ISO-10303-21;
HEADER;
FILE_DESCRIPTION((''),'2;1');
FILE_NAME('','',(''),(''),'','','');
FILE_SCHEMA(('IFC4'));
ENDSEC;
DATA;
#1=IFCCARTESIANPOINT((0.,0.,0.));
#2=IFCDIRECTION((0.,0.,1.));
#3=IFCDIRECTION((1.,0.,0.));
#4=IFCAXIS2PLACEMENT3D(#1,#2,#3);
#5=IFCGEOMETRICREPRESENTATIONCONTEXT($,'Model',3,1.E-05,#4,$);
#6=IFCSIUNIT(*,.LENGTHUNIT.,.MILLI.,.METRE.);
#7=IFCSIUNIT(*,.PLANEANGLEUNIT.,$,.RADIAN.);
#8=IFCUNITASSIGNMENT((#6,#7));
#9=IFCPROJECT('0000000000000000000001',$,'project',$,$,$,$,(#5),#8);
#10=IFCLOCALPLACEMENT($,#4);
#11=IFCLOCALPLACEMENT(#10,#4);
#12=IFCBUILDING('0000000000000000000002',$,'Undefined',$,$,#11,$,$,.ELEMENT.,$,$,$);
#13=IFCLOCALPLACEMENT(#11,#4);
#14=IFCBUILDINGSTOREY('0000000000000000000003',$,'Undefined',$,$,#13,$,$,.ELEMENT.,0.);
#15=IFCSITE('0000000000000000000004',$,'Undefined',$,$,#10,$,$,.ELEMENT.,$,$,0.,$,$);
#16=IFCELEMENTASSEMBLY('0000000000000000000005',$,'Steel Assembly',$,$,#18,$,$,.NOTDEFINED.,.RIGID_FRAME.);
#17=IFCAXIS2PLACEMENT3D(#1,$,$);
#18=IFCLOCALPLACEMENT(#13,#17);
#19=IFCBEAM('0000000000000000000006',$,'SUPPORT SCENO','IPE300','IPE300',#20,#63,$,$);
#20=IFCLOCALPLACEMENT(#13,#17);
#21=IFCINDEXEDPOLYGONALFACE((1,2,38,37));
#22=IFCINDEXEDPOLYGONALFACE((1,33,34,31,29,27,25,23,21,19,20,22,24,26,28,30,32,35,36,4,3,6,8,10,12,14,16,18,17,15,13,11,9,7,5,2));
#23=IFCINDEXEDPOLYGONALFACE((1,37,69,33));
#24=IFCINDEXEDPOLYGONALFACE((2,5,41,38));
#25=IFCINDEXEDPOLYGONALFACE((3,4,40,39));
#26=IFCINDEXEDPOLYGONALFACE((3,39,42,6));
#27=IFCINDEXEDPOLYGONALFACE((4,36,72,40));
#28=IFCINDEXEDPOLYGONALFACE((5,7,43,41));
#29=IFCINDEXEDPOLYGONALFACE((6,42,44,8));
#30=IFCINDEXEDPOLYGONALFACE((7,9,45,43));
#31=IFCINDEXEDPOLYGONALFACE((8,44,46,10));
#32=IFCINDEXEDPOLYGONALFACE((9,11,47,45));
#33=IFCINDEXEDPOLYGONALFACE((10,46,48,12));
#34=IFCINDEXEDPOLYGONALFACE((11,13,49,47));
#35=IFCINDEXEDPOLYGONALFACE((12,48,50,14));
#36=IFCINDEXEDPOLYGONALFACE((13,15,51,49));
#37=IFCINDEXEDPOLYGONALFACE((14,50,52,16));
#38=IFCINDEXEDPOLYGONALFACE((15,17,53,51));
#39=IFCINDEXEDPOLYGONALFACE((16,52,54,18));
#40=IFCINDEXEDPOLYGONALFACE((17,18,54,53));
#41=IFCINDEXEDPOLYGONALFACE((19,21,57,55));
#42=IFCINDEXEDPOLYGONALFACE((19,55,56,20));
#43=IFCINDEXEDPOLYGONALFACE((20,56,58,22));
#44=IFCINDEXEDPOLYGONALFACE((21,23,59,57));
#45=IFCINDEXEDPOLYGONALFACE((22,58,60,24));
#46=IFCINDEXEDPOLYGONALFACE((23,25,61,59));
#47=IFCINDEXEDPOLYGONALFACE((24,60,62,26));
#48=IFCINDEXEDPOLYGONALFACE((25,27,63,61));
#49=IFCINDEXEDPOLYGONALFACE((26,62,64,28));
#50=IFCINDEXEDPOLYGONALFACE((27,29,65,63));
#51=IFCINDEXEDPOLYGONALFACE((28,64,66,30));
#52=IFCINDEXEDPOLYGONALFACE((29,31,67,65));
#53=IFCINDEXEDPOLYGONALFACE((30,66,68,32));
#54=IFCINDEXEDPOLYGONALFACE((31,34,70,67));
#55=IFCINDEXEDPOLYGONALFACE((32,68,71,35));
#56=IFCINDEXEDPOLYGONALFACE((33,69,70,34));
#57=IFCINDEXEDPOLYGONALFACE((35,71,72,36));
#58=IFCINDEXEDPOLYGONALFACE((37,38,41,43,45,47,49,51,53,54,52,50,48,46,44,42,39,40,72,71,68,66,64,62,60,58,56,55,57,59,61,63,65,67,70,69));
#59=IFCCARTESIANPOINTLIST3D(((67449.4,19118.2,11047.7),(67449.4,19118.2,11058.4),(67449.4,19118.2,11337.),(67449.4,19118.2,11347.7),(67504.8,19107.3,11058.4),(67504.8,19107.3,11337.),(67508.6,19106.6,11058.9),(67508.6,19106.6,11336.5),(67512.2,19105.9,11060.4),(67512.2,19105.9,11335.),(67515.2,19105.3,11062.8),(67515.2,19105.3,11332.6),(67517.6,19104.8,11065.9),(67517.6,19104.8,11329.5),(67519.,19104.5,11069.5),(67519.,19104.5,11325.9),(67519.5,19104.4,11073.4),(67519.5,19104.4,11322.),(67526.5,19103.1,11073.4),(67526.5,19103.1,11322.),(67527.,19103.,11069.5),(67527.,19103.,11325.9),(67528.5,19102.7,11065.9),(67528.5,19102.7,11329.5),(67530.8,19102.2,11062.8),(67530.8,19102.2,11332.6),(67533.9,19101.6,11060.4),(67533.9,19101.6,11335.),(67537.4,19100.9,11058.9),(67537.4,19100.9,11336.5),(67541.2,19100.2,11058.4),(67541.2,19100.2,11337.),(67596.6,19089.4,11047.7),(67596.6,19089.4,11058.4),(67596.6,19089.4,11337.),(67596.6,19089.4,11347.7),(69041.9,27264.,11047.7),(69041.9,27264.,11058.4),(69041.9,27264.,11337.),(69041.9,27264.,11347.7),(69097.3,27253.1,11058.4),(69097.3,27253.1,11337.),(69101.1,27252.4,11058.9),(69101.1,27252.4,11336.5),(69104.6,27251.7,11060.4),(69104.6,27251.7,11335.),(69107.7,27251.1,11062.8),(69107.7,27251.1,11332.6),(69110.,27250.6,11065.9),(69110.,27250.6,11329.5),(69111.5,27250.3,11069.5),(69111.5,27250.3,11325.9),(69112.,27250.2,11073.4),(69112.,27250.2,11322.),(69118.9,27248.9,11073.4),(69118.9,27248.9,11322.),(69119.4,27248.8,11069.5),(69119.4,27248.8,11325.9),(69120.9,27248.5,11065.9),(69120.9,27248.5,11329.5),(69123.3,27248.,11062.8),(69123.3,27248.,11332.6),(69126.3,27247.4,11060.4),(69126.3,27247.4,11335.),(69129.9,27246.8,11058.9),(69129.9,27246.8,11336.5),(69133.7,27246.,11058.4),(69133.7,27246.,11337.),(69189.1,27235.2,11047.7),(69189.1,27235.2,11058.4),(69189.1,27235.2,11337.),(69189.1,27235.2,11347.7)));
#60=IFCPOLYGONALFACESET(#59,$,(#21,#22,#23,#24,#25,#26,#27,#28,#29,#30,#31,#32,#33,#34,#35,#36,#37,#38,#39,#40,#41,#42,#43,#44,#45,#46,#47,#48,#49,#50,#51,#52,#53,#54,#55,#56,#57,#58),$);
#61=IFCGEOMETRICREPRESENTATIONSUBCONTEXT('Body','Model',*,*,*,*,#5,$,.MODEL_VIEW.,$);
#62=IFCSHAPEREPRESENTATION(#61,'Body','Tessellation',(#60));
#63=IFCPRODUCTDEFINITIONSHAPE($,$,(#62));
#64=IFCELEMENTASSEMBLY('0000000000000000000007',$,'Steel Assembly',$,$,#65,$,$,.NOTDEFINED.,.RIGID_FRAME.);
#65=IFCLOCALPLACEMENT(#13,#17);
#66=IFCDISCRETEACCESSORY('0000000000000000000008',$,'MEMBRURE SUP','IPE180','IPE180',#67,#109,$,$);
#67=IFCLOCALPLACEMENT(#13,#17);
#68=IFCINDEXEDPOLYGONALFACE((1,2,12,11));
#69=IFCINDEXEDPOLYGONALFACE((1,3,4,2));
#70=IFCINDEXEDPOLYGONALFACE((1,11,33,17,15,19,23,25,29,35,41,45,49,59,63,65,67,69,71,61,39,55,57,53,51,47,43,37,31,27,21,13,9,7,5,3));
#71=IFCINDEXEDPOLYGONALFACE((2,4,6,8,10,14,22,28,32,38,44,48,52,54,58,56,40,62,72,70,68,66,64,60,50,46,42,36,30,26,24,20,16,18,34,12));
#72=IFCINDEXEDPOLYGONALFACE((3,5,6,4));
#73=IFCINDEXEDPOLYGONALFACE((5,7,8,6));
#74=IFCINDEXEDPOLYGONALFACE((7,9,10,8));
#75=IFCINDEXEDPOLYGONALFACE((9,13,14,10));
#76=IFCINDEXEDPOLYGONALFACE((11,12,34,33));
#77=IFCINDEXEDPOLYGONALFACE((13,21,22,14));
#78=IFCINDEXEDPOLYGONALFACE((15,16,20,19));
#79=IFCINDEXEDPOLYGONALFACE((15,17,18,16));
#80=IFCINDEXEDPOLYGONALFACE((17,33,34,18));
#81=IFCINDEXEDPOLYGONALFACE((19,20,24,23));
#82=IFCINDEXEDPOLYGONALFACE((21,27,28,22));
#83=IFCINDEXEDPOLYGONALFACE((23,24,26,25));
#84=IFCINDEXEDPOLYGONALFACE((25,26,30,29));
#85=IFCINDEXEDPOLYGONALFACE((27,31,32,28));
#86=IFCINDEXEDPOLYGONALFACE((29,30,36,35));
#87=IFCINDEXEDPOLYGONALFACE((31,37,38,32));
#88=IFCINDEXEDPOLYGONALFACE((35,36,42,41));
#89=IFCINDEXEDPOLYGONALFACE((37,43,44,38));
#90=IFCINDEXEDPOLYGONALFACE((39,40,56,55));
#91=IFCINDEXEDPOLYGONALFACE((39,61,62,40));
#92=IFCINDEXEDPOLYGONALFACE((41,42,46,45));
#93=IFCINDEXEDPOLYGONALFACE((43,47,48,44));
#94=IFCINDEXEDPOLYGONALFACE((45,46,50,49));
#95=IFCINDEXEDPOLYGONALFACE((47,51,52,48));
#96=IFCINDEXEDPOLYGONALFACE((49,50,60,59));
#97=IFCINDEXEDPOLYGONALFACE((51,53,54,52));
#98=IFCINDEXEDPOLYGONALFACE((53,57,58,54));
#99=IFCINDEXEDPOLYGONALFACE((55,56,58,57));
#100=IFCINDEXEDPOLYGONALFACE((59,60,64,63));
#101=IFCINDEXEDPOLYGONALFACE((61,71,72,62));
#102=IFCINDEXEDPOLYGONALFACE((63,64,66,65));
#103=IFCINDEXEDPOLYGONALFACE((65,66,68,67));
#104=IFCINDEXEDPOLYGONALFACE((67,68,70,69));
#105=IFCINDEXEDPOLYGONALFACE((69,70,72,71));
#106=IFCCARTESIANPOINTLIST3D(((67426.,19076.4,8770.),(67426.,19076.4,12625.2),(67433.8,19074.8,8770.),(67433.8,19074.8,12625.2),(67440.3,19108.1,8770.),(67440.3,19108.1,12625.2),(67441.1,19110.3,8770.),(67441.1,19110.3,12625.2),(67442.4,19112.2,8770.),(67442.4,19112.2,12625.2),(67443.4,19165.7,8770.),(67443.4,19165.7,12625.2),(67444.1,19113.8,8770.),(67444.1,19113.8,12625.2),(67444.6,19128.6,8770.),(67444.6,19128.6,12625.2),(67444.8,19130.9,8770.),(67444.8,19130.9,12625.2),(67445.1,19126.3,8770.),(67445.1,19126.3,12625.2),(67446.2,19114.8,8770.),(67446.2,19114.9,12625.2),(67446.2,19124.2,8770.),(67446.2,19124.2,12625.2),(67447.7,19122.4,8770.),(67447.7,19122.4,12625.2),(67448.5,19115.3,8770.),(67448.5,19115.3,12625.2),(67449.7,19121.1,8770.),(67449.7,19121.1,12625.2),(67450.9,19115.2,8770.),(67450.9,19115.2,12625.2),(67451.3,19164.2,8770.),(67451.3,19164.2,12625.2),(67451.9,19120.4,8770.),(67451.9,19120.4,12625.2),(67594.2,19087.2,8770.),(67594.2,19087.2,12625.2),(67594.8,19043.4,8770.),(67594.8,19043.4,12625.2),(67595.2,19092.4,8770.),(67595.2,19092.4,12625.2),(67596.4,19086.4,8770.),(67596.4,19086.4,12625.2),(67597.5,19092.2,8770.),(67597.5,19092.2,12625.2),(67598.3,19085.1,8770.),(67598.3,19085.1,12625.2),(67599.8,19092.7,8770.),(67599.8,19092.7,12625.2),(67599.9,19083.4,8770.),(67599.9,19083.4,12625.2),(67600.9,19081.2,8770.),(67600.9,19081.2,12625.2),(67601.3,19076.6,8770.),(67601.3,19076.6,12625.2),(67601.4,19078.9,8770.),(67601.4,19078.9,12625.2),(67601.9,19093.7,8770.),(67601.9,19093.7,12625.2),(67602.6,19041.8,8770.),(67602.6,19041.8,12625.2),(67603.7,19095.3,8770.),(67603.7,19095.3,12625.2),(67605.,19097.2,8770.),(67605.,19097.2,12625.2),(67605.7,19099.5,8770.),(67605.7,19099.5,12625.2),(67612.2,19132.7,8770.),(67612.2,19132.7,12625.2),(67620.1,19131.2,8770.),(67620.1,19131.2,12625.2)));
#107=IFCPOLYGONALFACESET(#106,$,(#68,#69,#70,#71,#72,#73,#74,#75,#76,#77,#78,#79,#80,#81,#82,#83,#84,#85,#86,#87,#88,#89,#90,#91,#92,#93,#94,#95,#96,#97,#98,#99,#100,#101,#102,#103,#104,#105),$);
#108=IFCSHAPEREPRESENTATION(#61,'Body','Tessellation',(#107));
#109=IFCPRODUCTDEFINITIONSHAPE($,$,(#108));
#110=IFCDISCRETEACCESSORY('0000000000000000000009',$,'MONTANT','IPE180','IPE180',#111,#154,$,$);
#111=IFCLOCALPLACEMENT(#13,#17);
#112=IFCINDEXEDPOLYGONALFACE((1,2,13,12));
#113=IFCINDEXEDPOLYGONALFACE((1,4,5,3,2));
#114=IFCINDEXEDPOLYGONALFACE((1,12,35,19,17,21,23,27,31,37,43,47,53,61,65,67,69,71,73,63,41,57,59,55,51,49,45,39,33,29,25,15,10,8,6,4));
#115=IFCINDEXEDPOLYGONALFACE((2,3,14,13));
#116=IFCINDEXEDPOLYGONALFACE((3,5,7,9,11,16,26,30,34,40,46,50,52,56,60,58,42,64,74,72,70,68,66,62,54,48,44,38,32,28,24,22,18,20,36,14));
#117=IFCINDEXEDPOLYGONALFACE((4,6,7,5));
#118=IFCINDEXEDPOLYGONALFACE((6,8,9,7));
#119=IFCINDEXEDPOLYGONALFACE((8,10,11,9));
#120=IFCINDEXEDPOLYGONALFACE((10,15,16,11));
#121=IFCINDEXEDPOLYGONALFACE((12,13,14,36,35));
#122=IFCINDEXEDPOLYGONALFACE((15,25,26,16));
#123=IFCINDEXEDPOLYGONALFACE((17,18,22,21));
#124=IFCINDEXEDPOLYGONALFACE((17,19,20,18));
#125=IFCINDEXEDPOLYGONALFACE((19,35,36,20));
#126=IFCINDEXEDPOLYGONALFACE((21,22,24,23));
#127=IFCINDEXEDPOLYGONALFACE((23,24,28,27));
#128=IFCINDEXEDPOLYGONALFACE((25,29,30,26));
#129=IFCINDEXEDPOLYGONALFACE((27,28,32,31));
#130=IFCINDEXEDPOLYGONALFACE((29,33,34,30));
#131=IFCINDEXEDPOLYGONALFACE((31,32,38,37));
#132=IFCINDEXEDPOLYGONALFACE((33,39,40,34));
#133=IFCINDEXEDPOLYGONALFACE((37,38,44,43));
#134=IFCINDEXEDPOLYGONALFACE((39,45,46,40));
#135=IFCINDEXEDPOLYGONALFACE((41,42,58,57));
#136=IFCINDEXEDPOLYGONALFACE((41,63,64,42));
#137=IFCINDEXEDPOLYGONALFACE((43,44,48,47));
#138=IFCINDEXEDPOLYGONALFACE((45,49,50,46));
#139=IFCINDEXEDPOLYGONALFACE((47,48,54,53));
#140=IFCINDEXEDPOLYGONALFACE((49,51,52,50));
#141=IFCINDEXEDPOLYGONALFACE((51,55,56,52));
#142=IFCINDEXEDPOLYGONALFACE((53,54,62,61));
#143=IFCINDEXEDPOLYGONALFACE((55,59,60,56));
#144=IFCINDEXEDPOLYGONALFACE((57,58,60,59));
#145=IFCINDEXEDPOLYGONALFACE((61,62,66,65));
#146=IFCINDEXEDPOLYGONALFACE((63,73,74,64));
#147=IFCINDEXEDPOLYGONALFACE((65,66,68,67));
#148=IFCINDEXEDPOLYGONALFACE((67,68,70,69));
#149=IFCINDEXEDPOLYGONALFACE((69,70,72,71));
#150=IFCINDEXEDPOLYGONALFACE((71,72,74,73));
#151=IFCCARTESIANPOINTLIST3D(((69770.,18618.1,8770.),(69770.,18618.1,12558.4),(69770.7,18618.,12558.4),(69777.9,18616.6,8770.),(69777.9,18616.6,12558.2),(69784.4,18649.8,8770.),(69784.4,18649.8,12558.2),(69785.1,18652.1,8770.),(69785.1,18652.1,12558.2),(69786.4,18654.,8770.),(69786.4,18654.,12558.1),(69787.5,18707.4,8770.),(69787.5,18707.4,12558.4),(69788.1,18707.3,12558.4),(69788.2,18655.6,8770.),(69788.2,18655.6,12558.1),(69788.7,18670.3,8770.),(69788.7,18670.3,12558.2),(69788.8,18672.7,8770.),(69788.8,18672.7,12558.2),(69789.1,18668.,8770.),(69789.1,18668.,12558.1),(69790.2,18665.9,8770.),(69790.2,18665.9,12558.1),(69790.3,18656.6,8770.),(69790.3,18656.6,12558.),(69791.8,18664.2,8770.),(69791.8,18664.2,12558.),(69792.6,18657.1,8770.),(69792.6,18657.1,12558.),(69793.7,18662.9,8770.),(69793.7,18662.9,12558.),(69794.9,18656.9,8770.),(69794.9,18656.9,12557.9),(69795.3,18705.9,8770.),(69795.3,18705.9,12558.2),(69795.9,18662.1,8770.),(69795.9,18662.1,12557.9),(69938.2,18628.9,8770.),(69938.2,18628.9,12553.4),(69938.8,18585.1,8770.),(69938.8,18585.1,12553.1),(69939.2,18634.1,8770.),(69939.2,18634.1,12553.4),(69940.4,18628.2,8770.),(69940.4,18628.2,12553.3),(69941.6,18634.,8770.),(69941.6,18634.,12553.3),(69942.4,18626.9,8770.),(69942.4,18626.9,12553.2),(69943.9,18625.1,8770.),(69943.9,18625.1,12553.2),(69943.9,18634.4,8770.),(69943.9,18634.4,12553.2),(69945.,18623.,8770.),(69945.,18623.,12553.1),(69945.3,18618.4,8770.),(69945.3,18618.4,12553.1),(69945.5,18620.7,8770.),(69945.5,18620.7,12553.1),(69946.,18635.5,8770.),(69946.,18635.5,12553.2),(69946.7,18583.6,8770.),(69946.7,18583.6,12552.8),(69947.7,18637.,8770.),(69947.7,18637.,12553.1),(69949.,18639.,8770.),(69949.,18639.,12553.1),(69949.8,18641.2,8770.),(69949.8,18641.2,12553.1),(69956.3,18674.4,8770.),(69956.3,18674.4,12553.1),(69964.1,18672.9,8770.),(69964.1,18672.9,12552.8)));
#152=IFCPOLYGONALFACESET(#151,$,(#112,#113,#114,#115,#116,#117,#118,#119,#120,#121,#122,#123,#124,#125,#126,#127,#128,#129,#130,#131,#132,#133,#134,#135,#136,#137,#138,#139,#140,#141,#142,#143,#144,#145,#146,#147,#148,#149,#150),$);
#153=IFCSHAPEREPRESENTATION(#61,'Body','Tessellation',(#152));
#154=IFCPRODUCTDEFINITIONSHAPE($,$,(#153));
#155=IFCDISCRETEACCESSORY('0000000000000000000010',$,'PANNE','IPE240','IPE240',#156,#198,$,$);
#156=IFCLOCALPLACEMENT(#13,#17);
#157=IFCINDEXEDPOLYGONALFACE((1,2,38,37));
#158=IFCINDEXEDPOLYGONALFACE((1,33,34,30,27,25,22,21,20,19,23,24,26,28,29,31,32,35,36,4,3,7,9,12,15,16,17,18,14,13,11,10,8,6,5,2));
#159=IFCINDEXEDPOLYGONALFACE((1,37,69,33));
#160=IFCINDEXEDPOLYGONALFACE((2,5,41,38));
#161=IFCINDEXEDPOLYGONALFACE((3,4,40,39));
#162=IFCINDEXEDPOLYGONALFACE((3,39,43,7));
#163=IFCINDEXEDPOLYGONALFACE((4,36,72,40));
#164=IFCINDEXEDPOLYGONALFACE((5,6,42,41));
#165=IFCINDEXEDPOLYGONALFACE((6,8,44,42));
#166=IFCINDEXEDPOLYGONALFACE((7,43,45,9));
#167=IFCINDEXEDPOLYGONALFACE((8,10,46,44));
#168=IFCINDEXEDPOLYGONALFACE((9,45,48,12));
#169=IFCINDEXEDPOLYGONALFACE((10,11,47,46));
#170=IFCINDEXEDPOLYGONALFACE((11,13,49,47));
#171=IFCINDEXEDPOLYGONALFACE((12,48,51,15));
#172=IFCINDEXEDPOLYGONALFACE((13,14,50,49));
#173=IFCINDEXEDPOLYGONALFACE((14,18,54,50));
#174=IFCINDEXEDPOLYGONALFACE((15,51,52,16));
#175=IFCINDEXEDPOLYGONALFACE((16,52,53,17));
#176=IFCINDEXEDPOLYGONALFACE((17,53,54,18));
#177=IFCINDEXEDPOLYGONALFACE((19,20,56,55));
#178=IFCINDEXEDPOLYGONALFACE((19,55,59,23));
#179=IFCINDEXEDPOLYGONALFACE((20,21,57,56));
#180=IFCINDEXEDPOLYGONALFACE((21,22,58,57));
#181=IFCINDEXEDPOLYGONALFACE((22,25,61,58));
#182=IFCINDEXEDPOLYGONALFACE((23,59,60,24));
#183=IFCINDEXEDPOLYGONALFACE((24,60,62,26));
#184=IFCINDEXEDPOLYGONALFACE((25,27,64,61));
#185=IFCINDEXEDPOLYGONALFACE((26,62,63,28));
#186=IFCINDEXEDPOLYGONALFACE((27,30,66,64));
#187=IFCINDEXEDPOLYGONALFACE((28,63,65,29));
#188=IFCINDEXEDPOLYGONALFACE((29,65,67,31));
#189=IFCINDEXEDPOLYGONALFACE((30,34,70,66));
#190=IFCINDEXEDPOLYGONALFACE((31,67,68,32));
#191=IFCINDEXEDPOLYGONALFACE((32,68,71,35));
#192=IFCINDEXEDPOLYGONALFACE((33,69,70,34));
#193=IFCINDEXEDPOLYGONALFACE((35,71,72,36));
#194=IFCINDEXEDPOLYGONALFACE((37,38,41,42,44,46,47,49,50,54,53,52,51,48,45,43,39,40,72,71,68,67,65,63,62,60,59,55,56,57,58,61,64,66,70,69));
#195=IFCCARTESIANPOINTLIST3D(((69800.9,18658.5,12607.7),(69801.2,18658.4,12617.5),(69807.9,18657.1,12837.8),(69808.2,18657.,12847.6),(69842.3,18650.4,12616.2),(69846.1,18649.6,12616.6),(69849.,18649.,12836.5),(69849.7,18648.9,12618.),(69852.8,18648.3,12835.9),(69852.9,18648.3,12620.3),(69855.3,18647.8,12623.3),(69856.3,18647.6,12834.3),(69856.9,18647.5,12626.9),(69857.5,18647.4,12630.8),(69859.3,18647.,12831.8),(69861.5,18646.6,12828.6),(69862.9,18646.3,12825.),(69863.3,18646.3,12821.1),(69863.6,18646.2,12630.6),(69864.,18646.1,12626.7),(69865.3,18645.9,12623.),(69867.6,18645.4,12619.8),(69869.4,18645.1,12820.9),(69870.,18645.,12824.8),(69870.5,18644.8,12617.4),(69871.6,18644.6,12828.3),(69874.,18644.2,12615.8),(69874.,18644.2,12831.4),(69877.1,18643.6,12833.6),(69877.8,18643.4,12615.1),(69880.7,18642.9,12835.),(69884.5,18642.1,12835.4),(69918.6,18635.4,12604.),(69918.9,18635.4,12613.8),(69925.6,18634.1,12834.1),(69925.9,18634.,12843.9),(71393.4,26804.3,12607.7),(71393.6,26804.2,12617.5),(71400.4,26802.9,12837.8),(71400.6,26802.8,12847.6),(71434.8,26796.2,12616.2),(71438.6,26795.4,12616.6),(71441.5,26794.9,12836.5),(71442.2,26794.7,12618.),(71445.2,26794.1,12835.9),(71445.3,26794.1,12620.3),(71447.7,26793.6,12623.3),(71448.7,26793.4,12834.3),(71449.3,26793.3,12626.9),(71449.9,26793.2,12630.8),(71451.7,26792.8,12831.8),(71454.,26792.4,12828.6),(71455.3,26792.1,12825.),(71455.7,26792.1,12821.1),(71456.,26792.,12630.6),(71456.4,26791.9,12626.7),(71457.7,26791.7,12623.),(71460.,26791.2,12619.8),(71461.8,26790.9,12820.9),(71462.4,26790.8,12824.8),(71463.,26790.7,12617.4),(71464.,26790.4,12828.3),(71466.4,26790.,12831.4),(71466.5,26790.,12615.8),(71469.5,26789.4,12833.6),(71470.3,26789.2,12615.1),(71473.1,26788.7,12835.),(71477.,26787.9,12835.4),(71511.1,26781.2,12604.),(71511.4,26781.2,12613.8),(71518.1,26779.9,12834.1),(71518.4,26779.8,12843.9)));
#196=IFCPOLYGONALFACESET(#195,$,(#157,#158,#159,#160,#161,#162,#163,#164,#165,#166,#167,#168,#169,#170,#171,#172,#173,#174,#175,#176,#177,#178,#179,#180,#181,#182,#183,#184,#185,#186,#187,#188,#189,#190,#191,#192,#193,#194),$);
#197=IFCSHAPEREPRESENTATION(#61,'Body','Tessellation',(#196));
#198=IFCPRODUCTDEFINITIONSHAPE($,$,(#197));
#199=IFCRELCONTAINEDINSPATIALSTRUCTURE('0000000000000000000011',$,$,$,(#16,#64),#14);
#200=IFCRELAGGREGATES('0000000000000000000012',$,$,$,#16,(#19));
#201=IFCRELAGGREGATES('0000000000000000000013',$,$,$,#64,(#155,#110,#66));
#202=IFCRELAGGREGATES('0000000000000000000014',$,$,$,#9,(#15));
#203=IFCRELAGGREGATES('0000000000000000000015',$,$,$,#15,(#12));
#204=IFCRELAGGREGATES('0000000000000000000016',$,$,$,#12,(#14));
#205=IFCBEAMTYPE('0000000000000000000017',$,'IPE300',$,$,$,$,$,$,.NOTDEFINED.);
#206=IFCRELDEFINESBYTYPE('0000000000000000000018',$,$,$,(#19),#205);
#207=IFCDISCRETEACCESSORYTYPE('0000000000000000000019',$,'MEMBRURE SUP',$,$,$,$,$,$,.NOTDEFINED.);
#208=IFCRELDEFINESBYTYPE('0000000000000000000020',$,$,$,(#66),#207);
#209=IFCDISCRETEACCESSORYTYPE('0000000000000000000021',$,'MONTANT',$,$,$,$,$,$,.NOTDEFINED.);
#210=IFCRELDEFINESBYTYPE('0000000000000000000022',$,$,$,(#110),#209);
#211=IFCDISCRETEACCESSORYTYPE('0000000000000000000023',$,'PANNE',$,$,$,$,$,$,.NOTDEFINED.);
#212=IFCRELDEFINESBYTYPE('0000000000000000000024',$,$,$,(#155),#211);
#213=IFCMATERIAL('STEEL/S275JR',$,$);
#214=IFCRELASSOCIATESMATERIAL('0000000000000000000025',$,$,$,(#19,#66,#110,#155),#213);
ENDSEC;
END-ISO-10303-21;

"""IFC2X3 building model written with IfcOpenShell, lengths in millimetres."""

from ifc_helpers import new_model, si_unit, frame, origin_with_axes, origin_2d_with_axis, place, context, subcontext, project, spatial, i_section, extrude, clip, halfspace, material, type_object, element, aggregate, save


model = new_model("IFC2X3")

# Units and contexts
model_context = context("Model", 3, precision=1e-05, world=origin_with_axes())
body_context = subcontext(model_context, "Body", "Model", "MODEL_VIEW")
ifc_project = project(units=[si_unit("LENGTHUNIT", "METRE", prefix="MILLI"), si_unit("PLANEANGLEUNIT", "RADIAN")], contexts=[model_context])

# Site, building, storey
site_placement = place(None, origin_with_axes())
site = spatial("IfcSite", under=ifc_project, at=site_placement, Name="Undefined", CompositionType="ELEMENT", RefElevation=0.0)
building_placement = place(site_placement, origin_with_axes())
building = spatial("IfcBuilding", under=site, at=building_placement, Name="Undefined", CompositionType="ELEMENT")
storey_placement = place(building_placement, origin_with_axes())
storey = spatial("IfcBuildingStorey", under=building, at=storey_placement, Name="Undefined", CompositionType="ELEMENT", Elevation=0.0)

# Element assembly, beam
ifc_material = material(Name="STEEL/S275JR")
beam_type_1 = type_object("IfcBeamType", Name="IPE300", PredefinedType="NOTDEFINED")
assembly_1_placement = place(storey_placement, origin_with_axes())
assembly_1 = element("IfcElementAssembly", 1, at=assembly_1_placement, inside=storey, Name="Steel Assembly", AssemblyPlace="NOTDEFINED", PredefinedType="RIGID_FRAME")
beam_1_placement = place(assembly_1_placement, frame((67523.0, 19103.8, 11197.7), z_axis=(0.0, 0.0, 1.0), x_axis=(0.191859, 0.981422, 0.0)))
beam_1 = element("IfcBeam", 2, at=beam_1_placement, type_object=beam_type_1, material=ifc_material, Name="SUPPORT SCENO", Description="IPE300", ObjectType="IPE300", context=body_context, shape_type="SweptSolid", body=[
    extrude(i_section(OverallWidth=150.0, OverallDepth=300.0, WebThickness=7.1, FlangeThickness=10.7, FilletRadius=15.0, at=origin_2d_with_axis()), frame((8300.0, 0.0, 0.0), z_axis=(-1.0, 0.0, 0.0), x_axis=(0.0, -1.0, 0.0)), (0.0, 0.0, 1.0), 8300.0),
])
aggregate(assembly_1, [beam_1])

# Element assembly, discrete accessories
assembly_2_placement = place(storey_placement, origin_with_axes())
assembly_2 = element("IfcElementAssembly", 3, at=assembly_2_placement, inside=storey, Name="Steel Assembly", AssemblyPlace="NOTDEFINED", PredefinedType="RIGID_FRAME")
discrete_accessory_type_1 = type_object("IfcDiscreteAccessoryType", Name="MEMBRURE SUP")
discrete_accessory_1_placement = place(assembly_2_placement, frame((67523.0, 19103.8, 12625.2), z_axis=(0.981422, -0.191859, 0.0), x_axis=(-0.000002, 0.0, -1.0)))
discrete_accessory_1 = element("IfcDiscreteAccessory", 4, at=discrete_accessory_1_placement, type_object=discrete_accessory_type_1, material=ifc_material, Name="MEMBRURE SUP", Description="IPE180", ObjectType="IPE180", context=body_context, shape_type="SweptSolid", body=[
    extrude(i_section(OverallWidth=91.0, OverallDepth=180.0, WebThickness=5.3, FlangeThickness=8.0, FilletRadius=9.0, at=origin_2d_with_axis()), frame((3855.2, 0.0, 0.0), z_axis=(-1.0, 0.0, 0.0), x_axis=(0.0, -1.0, 0.0)), (0.0, 0.0, 1.0), 3855.2),
])
discrete_accessory_type_2 = type_object("IfcDiscreteAccessoryType", Name="MONTANT")
discrete_accessory_2_placement = place(assembly_2_placement, frame((69867.1, 18645.5, 12528.2), z_axis=(-0.981422, 0.191859, 0.0), x_axis=(0.0, 0.0, -1.0)))
discrete_accessory_2 = element("IfcDiscreteAccessory", 5, at=discrete_accessory_2_placement, type_object=discrete_accessory_type_2, material=ifc_material, Name="MONTANT", Description="IPE180", ObjectType="IPE180", context=body_context, shape_type="Clipping", body=[
    clip(extrude(i_section(OverallWidth=91.0, OverallDepth=180.0, WebThickness=5.3, FlangeThickness=8.0, FilletRadius=9.0, at=origin_2d_with_axis()), frame((3758.2, 0.0, 0.0), z_axis=(-1.0, 0.0, 0.0), x_axis=(0.0, -1.0, 0.0)), (0.0, 0.0, 1.0), 3788.4), halfspace(frame((-32.4, 1850.0, 158.7), z_axis=(0.99952, 0.0, 0.030984), x_axis=(0.0, 1.0, 0.0)), True)),
])
discrete_accessory_type_3 = type_object("IfcDiscreteAccessoryType", Name="PANNE")
discrete_accessory_3_placement = place(assembly_2_placement, frame((69863.4, 18646.2, 12725.8), z_axis=(0.030408, -0.005945, 0.99952), x_axis=(0.191859, 0.981422, 0.0)))
discrete_accessory_3 = element("IfcDiscreteAccessory", 6, at=discrete_accessory_3_placement, type_object=discrete_accessory_type_3, material=ifc_material, Name="PANNE", Description="IPE240", ObjectType="IPE240", context=body_context, shape_type="SweptSolid", body=[
    extrude(i_section(OverallWidth=120.0, OverallDepth=240.0, WebThickness=6.2, FlangeThickness=9.8, FilletRadius=15.0, at=origin_2d_with_axis()), frame((8300.0, 0.0, 0.0), z_axis=(-1.0, 0.0, 0.0), x_axis=(0.0, -1.0, 0.0)), (0.0, 0.0, 1.0), 8300.0),
])
aggregate(assembly_2, [discrete_accessory_3, discrete_accessory_2, discrete_accessory_1])

save(model, "model.ifc")
